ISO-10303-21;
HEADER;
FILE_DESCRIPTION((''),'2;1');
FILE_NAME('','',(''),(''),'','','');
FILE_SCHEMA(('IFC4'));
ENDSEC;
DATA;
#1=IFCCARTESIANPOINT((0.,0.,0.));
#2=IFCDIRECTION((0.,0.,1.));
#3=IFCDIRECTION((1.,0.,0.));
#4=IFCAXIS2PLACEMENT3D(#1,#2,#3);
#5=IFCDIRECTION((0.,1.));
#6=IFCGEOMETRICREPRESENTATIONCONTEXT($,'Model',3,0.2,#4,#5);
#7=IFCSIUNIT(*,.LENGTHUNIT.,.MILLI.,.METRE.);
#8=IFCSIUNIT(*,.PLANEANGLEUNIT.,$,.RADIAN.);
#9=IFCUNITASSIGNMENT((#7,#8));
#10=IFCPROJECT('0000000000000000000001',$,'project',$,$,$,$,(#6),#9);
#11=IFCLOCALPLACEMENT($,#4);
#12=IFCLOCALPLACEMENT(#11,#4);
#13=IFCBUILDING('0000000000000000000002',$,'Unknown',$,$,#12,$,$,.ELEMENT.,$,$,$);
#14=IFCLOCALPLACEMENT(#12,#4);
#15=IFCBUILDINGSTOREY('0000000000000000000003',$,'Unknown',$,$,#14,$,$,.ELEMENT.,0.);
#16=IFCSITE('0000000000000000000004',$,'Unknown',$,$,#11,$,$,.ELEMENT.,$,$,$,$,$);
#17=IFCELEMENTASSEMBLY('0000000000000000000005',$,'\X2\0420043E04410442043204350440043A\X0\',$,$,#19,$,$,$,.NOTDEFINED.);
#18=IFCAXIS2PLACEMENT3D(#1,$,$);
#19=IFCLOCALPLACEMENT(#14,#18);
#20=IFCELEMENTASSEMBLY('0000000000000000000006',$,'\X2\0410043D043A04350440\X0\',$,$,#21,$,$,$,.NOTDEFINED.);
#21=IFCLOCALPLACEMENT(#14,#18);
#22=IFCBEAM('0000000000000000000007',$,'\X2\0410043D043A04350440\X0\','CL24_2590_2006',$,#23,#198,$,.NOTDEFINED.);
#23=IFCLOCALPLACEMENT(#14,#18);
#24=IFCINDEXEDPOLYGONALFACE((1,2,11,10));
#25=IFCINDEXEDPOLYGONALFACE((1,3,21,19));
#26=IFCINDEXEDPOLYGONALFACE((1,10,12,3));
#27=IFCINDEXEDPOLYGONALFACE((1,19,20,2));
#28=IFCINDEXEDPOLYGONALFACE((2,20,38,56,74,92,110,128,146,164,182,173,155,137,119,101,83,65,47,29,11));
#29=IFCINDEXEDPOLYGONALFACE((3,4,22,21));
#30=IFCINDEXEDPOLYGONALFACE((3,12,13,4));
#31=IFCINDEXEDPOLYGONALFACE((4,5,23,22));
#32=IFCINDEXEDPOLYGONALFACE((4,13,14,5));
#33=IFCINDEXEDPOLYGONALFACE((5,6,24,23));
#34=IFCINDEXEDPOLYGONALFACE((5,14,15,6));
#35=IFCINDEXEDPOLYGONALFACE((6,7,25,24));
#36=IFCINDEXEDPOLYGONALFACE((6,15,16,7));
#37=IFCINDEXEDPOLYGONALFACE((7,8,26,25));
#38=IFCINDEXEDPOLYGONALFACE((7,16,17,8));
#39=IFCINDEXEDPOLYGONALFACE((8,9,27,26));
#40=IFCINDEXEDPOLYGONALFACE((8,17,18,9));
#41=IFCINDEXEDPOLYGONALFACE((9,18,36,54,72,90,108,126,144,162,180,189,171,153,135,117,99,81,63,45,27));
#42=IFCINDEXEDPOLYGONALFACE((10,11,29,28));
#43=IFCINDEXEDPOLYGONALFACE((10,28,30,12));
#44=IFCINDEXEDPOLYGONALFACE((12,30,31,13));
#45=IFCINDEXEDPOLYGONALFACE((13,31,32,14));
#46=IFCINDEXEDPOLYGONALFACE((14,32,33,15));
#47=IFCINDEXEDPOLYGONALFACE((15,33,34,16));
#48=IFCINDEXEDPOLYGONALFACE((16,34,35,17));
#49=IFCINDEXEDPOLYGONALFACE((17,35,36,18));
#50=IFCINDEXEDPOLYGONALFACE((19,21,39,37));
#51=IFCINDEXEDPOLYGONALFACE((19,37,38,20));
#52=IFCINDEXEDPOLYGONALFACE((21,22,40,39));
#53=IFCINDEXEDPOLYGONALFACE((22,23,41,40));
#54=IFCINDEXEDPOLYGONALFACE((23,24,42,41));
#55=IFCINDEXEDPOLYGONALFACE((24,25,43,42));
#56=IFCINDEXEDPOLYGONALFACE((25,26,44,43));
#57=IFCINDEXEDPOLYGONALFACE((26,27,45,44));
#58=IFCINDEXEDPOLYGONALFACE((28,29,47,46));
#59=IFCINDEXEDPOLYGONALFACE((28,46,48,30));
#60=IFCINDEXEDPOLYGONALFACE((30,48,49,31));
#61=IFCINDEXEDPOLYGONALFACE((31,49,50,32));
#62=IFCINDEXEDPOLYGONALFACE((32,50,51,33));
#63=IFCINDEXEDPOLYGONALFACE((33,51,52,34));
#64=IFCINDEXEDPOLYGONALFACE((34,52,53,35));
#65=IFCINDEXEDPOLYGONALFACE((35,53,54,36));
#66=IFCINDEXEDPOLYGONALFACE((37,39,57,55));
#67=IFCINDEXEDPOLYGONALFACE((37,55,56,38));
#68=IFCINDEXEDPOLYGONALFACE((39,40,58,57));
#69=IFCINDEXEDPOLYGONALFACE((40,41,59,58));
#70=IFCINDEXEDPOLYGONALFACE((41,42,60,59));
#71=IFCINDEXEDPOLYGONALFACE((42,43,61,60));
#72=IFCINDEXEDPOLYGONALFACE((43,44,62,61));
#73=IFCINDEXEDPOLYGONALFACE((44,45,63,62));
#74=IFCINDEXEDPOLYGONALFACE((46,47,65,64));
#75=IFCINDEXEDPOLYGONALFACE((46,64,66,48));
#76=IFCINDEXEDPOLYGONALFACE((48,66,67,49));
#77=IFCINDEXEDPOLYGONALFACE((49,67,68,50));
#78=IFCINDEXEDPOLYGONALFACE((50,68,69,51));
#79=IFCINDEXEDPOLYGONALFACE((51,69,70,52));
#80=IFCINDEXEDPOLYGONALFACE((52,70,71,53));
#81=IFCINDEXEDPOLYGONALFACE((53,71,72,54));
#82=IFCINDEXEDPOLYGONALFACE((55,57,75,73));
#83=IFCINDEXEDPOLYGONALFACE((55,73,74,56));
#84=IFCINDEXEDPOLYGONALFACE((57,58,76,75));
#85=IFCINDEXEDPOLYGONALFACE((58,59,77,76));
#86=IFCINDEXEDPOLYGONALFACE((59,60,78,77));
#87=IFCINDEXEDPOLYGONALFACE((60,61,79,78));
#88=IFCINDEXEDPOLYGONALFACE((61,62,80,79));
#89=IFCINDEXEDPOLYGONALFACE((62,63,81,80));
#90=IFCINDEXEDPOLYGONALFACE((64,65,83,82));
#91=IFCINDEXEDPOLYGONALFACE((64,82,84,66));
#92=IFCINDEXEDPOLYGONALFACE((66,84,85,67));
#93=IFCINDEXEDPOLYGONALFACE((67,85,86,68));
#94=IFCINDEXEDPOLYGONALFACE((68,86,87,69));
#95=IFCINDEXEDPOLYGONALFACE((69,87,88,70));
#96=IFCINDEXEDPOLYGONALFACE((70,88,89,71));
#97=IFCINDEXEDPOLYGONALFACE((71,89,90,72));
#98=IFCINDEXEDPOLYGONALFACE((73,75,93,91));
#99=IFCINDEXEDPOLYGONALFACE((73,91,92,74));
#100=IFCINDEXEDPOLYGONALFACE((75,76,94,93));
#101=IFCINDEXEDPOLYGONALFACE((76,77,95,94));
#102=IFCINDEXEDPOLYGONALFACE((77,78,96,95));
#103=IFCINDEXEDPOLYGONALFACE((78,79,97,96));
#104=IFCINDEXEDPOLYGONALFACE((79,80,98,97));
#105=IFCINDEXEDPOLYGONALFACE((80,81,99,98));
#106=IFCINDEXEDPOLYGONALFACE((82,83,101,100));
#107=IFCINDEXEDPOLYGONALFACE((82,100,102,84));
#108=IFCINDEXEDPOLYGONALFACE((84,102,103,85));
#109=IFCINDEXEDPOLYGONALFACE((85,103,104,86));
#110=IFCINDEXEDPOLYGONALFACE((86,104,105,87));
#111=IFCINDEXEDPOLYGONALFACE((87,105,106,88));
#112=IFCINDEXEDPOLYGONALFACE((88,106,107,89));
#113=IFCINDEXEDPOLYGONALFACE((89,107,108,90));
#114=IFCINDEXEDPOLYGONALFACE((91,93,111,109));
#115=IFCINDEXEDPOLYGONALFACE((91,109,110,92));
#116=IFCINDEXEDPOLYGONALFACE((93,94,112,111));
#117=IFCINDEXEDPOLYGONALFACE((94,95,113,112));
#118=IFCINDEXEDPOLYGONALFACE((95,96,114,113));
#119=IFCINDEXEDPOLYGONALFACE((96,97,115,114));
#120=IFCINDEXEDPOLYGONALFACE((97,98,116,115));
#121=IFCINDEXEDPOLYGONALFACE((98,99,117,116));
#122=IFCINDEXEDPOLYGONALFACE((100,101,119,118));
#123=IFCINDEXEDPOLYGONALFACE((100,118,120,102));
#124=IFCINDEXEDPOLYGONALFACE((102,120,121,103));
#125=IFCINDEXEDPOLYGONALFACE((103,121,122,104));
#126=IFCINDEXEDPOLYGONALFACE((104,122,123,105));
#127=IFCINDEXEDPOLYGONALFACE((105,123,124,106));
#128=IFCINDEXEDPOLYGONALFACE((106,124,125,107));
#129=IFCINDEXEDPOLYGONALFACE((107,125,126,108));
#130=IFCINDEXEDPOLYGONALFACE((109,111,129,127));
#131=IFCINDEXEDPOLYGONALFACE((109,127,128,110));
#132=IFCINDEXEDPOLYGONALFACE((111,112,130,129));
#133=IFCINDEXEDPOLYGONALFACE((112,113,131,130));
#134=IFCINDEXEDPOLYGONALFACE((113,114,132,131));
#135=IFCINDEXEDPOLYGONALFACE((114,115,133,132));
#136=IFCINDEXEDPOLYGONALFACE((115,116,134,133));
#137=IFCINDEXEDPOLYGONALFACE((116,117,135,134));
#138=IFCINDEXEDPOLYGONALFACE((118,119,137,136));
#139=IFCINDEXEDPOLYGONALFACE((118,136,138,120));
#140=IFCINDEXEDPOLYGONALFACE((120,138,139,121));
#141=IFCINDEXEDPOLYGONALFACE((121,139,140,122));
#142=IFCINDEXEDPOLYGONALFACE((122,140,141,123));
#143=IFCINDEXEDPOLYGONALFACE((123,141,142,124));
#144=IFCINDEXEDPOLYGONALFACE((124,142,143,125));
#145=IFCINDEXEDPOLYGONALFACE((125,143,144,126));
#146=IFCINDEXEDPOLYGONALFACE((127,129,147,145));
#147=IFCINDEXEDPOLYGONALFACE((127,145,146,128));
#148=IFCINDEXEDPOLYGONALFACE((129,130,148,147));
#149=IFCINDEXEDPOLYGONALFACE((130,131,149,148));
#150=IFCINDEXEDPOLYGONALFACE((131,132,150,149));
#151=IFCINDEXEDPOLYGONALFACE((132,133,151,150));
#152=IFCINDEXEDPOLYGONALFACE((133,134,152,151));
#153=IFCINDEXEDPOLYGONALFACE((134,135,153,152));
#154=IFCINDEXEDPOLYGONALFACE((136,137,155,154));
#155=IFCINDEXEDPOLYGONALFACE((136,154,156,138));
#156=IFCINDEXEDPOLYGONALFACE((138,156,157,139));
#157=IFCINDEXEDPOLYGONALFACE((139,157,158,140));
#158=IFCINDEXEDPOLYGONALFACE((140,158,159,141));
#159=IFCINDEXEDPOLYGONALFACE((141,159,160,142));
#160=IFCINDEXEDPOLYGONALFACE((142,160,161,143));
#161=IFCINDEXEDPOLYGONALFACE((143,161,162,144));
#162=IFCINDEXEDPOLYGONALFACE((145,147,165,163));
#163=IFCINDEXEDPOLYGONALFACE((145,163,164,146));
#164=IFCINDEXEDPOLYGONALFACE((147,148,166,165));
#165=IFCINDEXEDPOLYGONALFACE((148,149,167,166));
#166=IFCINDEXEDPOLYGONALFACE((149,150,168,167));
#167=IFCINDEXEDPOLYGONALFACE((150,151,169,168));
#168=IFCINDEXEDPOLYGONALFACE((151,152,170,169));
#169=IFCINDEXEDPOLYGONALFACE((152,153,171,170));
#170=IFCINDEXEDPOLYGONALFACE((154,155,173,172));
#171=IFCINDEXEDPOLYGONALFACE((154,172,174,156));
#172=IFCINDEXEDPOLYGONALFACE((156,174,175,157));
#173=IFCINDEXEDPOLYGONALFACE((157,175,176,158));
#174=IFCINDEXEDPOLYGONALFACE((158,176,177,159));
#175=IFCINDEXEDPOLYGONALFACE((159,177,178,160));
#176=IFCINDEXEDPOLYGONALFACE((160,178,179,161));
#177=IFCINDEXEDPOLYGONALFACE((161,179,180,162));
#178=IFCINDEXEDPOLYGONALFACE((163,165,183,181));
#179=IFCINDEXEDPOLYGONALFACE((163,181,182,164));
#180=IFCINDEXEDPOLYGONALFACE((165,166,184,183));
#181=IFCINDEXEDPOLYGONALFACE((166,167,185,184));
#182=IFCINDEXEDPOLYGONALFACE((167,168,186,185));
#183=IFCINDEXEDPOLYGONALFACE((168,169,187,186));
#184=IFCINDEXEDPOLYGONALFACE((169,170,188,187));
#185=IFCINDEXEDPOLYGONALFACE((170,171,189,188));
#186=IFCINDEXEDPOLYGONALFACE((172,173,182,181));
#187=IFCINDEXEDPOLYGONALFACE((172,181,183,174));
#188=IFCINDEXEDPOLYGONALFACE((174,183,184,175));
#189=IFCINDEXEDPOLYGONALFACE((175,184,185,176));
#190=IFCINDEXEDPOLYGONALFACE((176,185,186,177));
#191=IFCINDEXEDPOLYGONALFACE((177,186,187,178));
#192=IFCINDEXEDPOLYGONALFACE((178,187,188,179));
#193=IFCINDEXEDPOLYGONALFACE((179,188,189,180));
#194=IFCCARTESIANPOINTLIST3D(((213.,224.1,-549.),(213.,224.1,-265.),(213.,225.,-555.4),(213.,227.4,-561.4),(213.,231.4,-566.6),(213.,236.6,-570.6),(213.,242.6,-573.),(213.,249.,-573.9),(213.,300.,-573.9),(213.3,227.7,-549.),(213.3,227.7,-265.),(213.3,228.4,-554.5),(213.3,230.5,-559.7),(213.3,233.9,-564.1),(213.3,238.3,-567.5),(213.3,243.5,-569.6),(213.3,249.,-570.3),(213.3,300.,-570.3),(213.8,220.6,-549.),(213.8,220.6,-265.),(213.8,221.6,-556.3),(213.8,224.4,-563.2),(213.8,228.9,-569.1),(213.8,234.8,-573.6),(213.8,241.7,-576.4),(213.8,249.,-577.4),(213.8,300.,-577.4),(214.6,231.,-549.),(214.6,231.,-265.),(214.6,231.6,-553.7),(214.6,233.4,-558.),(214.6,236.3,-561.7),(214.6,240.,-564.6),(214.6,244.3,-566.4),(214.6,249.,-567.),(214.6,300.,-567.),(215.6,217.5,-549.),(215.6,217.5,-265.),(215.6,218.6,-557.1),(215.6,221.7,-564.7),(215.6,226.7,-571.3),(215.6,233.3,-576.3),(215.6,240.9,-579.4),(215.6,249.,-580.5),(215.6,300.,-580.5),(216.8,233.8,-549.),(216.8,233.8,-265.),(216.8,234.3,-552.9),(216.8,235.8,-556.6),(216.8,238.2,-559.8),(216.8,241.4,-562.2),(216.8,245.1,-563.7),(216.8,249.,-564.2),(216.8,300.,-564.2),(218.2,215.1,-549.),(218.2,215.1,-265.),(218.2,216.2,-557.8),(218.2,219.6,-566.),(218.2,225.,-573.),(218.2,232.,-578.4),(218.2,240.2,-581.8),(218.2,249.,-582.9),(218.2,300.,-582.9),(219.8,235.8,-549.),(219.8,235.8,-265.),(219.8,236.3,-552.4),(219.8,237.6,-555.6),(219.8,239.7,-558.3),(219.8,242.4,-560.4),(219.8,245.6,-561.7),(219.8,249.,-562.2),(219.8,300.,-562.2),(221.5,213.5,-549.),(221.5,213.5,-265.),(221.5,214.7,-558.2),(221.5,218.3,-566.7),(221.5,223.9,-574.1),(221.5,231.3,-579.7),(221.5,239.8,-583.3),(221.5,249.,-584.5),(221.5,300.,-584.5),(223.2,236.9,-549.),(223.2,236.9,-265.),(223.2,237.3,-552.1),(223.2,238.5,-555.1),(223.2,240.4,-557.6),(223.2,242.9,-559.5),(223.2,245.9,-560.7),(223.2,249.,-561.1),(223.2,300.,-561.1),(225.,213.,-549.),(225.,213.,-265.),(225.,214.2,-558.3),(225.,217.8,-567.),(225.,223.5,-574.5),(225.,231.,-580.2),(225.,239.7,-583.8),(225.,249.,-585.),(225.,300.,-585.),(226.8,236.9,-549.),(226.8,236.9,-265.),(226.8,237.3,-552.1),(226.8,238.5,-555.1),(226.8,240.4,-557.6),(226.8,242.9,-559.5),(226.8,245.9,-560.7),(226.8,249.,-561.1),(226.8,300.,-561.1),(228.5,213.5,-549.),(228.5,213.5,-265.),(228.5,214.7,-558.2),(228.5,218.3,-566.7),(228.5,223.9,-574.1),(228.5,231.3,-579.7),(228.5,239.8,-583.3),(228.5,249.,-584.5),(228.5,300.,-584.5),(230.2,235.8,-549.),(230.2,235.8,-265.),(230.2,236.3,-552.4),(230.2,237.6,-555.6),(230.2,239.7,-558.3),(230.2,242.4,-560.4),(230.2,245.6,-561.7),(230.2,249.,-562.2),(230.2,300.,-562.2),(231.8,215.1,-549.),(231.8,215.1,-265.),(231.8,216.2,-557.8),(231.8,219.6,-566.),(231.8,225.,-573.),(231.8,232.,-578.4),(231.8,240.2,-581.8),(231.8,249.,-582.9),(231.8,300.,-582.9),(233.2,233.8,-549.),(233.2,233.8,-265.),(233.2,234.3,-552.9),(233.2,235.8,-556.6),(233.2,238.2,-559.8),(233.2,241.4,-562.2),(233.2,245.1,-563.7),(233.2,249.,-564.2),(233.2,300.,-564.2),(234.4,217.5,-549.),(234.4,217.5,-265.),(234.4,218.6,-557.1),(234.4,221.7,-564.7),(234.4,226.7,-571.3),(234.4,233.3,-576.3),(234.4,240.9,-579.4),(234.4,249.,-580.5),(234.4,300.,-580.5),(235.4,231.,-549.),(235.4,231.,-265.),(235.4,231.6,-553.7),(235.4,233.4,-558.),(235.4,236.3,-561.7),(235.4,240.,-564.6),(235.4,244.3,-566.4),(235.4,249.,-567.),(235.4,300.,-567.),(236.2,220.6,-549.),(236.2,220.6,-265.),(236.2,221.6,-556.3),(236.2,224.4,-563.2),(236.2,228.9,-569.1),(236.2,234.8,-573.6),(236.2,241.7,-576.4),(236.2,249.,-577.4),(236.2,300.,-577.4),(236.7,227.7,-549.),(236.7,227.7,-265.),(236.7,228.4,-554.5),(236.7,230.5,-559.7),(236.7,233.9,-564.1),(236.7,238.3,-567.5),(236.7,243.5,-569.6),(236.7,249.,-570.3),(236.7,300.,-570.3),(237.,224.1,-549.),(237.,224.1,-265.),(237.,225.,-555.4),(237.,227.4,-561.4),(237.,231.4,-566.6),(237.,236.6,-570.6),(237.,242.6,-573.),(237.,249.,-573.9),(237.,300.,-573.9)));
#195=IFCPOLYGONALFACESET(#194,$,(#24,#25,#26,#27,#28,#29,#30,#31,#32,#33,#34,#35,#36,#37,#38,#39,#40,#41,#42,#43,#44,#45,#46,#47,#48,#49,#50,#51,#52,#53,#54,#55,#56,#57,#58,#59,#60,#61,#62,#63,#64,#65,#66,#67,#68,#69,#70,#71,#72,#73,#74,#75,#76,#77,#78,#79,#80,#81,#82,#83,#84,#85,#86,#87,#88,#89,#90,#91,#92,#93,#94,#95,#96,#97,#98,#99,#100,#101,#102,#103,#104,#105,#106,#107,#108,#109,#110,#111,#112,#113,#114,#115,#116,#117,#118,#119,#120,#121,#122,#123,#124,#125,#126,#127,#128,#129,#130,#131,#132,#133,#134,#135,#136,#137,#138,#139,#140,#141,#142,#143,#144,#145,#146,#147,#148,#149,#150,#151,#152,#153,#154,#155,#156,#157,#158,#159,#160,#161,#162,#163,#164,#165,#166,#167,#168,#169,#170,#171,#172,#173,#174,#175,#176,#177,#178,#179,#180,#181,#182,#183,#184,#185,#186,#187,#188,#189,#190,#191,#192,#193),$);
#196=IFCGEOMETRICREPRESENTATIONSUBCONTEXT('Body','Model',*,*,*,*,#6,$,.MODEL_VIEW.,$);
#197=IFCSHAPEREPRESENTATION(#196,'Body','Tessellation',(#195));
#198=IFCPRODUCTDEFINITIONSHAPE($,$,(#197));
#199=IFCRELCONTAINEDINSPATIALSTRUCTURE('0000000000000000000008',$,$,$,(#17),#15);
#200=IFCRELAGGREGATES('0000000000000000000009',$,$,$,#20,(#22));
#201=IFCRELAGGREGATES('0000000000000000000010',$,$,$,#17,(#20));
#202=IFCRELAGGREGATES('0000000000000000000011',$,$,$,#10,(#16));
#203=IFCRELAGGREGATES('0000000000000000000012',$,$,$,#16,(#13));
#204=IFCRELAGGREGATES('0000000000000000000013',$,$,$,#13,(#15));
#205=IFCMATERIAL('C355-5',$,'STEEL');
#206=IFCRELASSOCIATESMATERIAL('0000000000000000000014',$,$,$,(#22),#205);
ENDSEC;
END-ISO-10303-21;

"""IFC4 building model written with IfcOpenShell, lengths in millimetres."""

from ifc_helpers import new_model, entity, si_unit, direction, frame, origin_with_axes, place, context, subcontext, project, spatial, line, indexed_curve, outline, extrude, material, element, aggregate, save


model = new_model("IFC4")

# Units and contexts
model_context = context("Model", 3, precision=0.2, world=origin_with_axes(), true_north=direction((0.0, 1.0)))
body_context = subcontext(model_context, "Body", "Model", "MODEL_VIEW")
ifc_project = project(units=[si_unit("LENGTHUNIT", "METRE", prefix="MILLI"), si_unit("PLANEANGLEUNIT", "RADIAN")], contexts=[model_context])

# Site, building, storey
site_placement = place(None, origin_with_axes())
site = spatial("IfcSite", under=ifc_project, at=site_placement, Name="Unknown", CompositionType="ELEMENT")
building_placement = place(site_placement, origin_with_axes())
building = spatial("IfcBuilding", under=site, at=building_placement, Name="Unknown", CompositionType="ELEMENT")
storey_placement = place(building_placement, origin_with_axes())
storey = spatial("IfcBuildingStorey", under=building, at=storey_placement, Name="Unknown", CompositionType="ELEMENT", Elevation=0.0)

# Element assemblies, beam, voiding feature
assembly_1_placement = place(storey_placement, frame((80.0, 80.0, -300.0), z_axis=(0.0, -1.0, 0.0), x_axis=(0.0, 0.0, -1.0)))
assembly_1 = element("IfcElementAssembly", 1, at=assembly_1_placement, inside=storey, Name="Ростверк", PredefinedType="NOTDEFINED")
ifc_material_1 = material(Name="C355-5", Category="STEEL")
assembly_2_placement = place(assembly_1_placement, frame((-215.0, 145.0, -145.0), z_axis=(0.0, 0.0, 1.0), x_axis=(1.0, 0.0, 0.0)))
assembly_2 = element("IfcElementAssembly", 2, at=assembly_2_placement, Name="Анкер", PredefinedType="NOTDEFINED")
beam_1_placement = place(assembly_2_placement, origin_with_axes())
beam_1 = element("IfcBeam", 3, at=beam_1_placement, material=ifc_material_1, Name="Анкер", Description="CL24_2590_2006", PredefinedType="NOTDEFINED", context=body_context, shape_type="SolidModel", body=[
    entity("IfcSweptDiskSolid", entity("IfcIndexedPolyCurve", entity("IfcCartesianPointList3D", [[0.0, 0.0, 0.0], [464.0, 0.0, 0.0], [481.0, 0.0, -7.0], [488.0, 0.0, -24.0], [488.0, 0.0, -75.0]]), [entity("IfcLineIndex", [1, 2]), entity("IfcArcIndex", [2, 3, 4]), entity("IfcLineIndex", [4, 5])]), 12.0),
])
voiding_feature_1_placement = place(beam_1_placement, frame((0.0, 0.0, 0.0), z_axis=(0.0, -1.0, 0.0), x_axis=(1.0, 0.0, 0.0)))
element("IfcVoidingFeature", 4, at=voiding_feature_1_placement, cuts=beam_1, Name="Анкер", PredefinedType="HOLE", context=body_context, shape_type="SolidModel", body=[
    extrude(outline(indexed_curve([(12.5, 0.0), (12.2, 2.8), (11.3, 5.4), (9.8, 7.8), (7.8, 9.8), (5.4, 11.3), (2.8, 12.2), (0.0, 12.5), (-2.8, 12.2), (-5.4, 11.3), (-7.8, 9.8), (-9.8, 7.8), (-11.3, 5.4), (-12.2, 2.8), (-12.5, 0.0), (-12.2, -2.8), (-11.3, -5.4), (-9.8, -7.8), (-7.8, -9.8), (-5.4, -11.3), (-2.8, -12.2), (0.0, -12.5), (2.8, -12.2), (5.4, -11.3), (7.8, -9.8), (9.8, -7.8), (11.3, -5.4), (12.2, -2.8)], segments=[line(1, 2, 3, 4, 5, 6, 7, 8, 9, 10, 11, 12, 13, 14, 15, 16, 17, 18, 19, 20, 21, 22, 23, 24, 25, 26, 27, 28, 1)])), frame((0.0, 0.0, 0.0), z_axis=(-1.0, 0.0, 0.0), x_axis=(0.0, 0.0, 1.0)), (0.0, 0.0, -1.0), 180.0),
])
aggregate(assembly_2, [beam_1])
aggregate(assembly_1, [assembly_2])

save(model, "model.ifc")
